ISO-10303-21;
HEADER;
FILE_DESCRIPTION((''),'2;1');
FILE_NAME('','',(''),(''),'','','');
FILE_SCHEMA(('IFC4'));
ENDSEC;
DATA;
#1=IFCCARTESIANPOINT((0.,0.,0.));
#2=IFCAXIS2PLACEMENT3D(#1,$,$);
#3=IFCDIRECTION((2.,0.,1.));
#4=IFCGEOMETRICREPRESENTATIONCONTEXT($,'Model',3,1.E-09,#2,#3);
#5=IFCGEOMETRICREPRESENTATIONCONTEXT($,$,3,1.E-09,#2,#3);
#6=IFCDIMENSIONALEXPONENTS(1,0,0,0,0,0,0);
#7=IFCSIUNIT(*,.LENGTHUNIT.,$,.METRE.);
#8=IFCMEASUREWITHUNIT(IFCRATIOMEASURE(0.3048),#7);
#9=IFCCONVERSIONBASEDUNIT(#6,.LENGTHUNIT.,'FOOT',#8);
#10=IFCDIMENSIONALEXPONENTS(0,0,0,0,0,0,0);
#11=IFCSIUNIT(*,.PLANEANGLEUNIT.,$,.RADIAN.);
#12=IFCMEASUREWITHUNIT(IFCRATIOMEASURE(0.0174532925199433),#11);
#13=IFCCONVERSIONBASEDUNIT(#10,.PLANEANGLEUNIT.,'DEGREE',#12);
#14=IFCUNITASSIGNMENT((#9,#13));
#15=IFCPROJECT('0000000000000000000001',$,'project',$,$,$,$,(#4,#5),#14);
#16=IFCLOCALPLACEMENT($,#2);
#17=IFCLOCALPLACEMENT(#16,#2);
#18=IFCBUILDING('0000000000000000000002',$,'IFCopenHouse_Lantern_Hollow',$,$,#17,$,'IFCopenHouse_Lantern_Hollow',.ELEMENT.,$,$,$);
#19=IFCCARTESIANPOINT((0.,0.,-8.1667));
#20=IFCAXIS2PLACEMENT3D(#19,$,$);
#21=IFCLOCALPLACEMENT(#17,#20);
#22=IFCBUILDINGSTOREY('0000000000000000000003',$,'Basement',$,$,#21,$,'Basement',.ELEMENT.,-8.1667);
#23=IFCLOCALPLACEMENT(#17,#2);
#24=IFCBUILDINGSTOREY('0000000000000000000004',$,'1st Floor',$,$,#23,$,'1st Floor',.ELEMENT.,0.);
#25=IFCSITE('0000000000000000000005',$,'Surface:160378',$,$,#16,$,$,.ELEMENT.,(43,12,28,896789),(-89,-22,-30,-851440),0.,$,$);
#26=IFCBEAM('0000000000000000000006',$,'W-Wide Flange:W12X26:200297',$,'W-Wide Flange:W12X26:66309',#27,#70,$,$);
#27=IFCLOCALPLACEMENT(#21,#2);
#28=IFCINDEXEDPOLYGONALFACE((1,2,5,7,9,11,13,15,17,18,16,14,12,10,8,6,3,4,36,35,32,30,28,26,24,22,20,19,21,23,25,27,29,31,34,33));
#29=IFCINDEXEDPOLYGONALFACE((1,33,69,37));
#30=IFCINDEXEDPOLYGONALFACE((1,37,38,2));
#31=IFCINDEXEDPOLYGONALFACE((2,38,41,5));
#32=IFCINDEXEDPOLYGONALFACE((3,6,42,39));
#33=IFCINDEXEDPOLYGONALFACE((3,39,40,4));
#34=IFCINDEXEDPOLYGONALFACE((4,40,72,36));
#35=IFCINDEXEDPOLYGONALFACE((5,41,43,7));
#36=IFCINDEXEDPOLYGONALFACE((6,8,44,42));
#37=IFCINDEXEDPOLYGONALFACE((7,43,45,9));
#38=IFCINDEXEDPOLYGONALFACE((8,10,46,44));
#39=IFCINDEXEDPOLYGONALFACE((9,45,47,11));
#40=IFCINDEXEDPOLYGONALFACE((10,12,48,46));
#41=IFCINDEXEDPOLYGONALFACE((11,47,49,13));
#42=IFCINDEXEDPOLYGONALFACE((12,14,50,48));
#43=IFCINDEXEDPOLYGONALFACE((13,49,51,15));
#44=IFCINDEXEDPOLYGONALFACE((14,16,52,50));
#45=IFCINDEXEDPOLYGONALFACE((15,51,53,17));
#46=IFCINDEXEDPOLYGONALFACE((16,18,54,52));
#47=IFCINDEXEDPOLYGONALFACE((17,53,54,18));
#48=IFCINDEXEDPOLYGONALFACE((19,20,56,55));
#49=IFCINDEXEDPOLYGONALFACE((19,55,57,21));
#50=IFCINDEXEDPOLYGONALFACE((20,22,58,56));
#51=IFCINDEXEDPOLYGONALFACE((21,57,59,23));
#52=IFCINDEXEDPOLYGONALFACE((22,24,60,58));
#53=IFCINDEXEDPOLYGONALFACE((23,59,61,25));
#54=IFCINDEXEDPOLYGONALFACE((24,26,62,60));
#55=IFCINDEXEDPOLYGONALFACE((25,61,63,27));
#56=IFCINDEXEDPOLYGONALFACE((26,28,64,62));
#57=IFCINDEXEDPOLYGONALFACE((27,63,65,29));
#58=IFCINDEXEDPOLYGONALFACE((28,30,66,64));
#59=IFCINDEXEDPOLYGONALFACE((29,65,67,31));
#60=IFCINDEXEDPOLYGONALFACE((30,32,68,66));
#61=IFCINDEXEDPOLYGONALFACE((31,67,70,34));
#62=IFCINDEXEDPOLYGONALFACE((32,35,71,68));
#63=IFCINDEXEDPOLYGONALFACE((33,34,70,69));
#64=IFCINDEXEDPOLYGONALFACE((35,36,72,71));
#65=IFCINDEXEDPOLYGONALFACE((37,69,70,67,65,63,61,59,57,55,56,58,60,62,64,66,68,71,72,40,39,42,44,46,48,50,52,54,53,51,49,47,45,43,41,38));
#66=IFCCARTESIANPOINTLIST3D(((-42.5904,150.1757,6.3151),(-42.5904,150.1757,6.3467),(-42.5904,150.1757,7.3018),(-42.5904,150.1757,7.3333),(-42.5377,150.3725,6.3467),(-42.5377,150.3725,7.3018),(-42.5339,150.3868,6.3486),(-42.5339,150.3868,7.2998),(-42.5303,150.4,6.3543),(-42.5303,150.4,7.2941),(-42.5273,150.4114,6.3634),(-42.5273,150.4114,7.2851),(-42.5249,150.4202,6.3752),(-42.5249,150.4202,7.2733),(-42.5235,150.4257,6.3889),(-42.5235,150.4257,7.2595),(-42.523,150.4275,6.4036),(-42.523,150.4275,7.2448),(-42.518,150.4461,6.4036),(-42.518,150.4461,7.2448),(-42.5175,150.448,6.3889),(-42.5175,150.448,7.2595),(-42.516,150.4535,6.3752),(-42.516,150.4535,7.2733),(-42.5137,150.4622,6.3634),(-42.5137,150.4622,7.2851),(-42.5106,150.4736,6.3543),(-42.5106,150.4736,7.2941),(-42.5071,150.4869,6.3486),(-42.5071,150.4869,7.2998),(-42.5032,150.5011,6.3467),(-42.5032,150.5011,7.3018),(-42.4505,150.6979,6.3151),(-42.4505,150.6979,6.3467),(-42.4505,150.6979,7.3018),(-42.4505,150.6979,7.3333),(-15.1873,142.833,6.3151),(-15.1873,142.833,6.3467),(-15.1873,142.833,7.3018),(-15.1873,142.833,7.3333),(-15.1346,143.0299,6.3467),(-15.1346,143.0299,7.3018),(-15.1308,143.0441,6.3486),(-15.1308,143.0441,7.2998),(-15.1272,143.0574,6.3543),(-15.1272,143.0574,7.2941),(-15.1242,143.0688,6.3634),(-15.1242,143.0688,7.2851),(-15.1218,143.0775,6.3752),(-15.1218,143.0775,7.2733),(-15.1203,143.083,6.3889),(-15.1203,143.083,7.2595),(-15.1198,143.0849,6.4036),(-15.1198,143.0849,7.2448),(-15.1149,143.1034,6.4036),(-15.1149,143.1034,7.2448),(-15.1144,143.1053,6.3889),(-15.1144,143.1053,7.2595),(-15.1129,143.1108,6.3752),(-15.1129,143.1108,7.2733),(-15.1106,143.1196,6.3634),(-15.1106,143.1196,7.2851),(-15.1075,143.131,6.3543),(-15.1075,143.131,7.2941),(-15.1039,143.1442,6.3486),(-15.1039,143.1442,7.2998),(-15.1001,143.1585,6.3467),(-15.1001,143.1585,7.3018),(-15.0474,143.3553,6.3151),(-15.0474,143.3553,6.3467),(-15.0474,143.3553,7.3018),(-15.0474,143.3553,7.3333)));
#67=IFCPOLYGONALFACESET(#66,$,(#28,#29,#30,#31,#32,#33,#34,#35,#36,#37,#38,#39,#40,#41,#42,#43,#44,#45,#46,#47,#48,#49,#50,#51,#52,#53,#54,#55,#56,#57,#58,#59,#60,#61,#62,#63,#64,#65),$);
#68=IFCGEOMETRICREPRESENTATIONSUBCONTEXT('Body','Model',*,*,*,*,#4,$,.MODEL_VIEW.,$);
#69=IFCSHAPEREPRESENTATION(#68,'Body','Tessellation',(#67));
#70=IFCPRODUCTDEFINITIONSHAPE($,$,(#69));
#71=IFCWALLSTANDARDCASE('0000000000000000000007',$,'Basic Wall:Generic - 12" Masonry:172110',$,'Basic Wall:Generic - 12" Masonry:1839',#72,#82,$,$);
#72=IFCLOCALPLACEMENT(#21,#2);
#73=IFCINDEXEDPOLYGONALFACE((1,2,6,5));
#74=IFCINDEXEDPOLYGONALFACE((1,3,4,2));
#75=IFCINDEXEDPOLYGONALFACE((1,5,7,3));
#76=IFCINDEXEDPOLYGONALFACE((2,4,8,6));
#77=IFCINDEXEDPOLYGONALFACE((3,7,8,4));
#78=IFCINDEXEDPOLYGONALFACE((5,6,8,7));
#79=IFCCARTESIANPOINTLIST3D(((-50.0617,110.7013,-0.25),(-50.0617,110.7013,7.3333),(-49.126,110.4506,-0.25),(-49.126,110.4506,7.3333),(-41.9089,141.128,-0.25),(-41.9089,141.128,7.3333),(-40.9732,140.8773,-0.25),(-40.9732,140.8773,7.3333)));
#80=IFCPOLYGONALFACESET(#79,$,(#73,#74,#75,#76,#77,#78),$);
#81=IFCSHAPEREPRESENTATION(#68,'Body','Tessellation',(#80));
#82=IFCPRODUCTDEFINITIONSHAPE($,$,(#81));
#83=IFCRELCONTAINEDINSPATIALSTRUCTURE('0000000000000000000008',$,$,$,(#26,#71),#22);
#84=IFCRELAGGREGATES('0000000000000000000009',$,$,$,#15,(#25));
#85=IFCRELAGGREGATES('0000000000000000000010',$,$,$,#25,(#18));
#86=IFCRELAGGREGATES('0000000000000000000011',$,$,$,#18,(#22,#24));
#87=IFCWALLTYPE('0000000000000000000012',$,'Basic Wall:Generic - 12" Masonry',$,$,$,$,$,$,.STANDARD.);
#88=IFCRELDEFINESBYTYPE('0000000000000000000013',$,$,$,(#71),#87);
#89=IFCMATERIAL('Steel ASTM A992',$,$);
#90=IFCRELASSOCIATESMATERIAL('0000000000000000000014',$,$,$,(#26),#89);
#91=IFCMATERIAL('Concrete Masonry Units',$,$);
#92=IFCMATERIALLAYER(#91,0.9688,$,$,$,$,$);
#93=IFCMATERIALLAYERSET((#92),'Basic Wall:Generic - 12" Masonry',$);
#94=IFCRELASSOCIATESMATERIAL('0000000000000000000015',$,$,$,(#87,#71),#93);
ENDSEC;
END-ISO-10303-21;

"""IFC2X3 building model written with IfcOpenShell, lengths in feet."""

from ifc_helpers import new_model, entity, si_unit, converted_unit, direction, frame, frame_2d, origin, place, context, subcontext, project, spatial, rectangle, i_section, extrude, material, layer, layer_set, layer_usage, type_object, element, save


model = new_model("IFC2X3")

# Units and contexts
model_context = context("Model", 3, precision=1e-09, world=origin(), true_north=direction((2.0, 0.0, 1.0)))
context_of_model = context(None, 3, precision=1e-09, world=origin(), true_north=direction((2.0, 0.0, 1.0)))
body_context = subcontext(model_context, "Body", "Model", "MODEL_VIEW")
ifc_project = project(units=[converted_unit("LENGTHUNIT", "FOOT", entity("IfcRatioMeasure", 0.3048), si_unit("LENGTHUNIT", "METRE"), dimensions=[1, 0, 0, 0, 0, 0, 0]), converted_unit("PLANEANGLEUNIT", "DEGREE", entity("IfcRatioMeasure", 0.0174532925199433), si_unit("PLANEANGLEUNIT", "RADIAN"), dimensions=[0, 0, 0, 0, 0, 0, 0])], contexts=[model_context, context_of_model])

# Site, building, storey
site_placement = place(None, origin())
site = spatial("IfcSite", under=ifc_project, at=site_placement, Name="Surface:160378", CompositionType="ELEMENT", RefLatitude=(43, 12, 28, 896789), RefLongitude=(-89, -22, -30, -851440), RefElevation=0.0)
building_placement = place(site_placement, origin())
building = spatial("IfcBuilding", under=site, at=building_placement, Name="IFCopenHouse_Lantern_Hollow", LongName="IFCopenHouse_Lantern_Hollow", CompositionType="ELEMENT")
storey_1_placement = place(building_placement, frame((0.0, 0.0, -8.1667)))
storey_1 = spatial("IfcBuildingStorey", under=building, at=storey_1_placement, Name="Basement", LongName="Basement", CompositionType="ELEMENT", Elevation=-8.1667)

# Beam
ifc_material_1 = material(Name="Steel ASTM A992")
beam_placement = place(storey_1_placement, frame((-42.5205, 150.4368, 8.1667), z_axis=(0.0, 0.0, 1.0), x_axis=(0.965926, -0.258819, 0.0)))
element("IfcBeam", 1, at=beam_placement, inside=storey_1, material=ifc_material_1, Name="W-Wide Flange:W12X26:200297", ObjectType="W-Wide Flange:W12X26:66309", context=body_context, shape_type="SweptSolid", body=[
    extrude(i_section(OverallWidth=0.5407, OverallDepth=1.0182, WebThickness=0.0192, FlangeThickness=0.0316, FilletRadius=0.057, at=frame_2d((0.0, 0.0), x_axis=(0.0, 1.0))), frame((0.0, 0.0, -1.3424), z_axis=(1.0, 0.0, 0.0), x_axis=(0.0, 0.0, -1.0)), (0.0, 0.0, 1.0), 28.3698),
])

# Wall
ifc_material_2 = material(Name="Concrete Masonry Units")
ifc_layer_1 = layer(ifc_material_2, 0.9688)
ifc_layer_set_1 = layer_set([ifc_layer_1], Name="Basic Wall:Generic - 12\" Masonry")
ifc_layer_usage_1 = layer_usage(ifc_layer_set_1, "AXIS2", "NEGATIVE", 0.4844)
wall_type_1 = type_object("IfcWallType", Name="Basic Wall:Generic - 12\" Masonry", PredefinedType="STANDARD", material=ifc_layer_set_1)
wall_1_placement = place(storey_1_placement, frame((-41.4411, 141.0026, -0.25), z_axis=(0.0, 0.0, 1.0), x_axis=(-0.258819, -0.965926, 0.0)))
element("IfcWallStandardCase", 2, at=wall_1_placement, inside=storey_1, type_object=wall_type_1, material=ifc_layer_usage_1, Name="Basic Wall:Generic - 12\" Masonry:172110", ObjectType="Basic Wall:Generic - 12\" Masonry:1839", context=body_context, shape_type="SweptSolid", body=[
    extrude(rectangle(XDim=31.5, YDim=0.9688, at=frame_2d((15.75, 0.0), x_axis=(-1.0, 0.0))), origin(), (0.0, 0.0, 1.0), 7.5833),
])

# Shared definitions
storey_2_placement = place(building_placement, origin())
storey_2 = spatial("IfcBuildingStorey", under=building, at=storey_2_placement, Name="1st Floor", LongName="1st Floor", CompositionType="ELEMENT", Elevation=0.0)

save(model, "model.ifc")
